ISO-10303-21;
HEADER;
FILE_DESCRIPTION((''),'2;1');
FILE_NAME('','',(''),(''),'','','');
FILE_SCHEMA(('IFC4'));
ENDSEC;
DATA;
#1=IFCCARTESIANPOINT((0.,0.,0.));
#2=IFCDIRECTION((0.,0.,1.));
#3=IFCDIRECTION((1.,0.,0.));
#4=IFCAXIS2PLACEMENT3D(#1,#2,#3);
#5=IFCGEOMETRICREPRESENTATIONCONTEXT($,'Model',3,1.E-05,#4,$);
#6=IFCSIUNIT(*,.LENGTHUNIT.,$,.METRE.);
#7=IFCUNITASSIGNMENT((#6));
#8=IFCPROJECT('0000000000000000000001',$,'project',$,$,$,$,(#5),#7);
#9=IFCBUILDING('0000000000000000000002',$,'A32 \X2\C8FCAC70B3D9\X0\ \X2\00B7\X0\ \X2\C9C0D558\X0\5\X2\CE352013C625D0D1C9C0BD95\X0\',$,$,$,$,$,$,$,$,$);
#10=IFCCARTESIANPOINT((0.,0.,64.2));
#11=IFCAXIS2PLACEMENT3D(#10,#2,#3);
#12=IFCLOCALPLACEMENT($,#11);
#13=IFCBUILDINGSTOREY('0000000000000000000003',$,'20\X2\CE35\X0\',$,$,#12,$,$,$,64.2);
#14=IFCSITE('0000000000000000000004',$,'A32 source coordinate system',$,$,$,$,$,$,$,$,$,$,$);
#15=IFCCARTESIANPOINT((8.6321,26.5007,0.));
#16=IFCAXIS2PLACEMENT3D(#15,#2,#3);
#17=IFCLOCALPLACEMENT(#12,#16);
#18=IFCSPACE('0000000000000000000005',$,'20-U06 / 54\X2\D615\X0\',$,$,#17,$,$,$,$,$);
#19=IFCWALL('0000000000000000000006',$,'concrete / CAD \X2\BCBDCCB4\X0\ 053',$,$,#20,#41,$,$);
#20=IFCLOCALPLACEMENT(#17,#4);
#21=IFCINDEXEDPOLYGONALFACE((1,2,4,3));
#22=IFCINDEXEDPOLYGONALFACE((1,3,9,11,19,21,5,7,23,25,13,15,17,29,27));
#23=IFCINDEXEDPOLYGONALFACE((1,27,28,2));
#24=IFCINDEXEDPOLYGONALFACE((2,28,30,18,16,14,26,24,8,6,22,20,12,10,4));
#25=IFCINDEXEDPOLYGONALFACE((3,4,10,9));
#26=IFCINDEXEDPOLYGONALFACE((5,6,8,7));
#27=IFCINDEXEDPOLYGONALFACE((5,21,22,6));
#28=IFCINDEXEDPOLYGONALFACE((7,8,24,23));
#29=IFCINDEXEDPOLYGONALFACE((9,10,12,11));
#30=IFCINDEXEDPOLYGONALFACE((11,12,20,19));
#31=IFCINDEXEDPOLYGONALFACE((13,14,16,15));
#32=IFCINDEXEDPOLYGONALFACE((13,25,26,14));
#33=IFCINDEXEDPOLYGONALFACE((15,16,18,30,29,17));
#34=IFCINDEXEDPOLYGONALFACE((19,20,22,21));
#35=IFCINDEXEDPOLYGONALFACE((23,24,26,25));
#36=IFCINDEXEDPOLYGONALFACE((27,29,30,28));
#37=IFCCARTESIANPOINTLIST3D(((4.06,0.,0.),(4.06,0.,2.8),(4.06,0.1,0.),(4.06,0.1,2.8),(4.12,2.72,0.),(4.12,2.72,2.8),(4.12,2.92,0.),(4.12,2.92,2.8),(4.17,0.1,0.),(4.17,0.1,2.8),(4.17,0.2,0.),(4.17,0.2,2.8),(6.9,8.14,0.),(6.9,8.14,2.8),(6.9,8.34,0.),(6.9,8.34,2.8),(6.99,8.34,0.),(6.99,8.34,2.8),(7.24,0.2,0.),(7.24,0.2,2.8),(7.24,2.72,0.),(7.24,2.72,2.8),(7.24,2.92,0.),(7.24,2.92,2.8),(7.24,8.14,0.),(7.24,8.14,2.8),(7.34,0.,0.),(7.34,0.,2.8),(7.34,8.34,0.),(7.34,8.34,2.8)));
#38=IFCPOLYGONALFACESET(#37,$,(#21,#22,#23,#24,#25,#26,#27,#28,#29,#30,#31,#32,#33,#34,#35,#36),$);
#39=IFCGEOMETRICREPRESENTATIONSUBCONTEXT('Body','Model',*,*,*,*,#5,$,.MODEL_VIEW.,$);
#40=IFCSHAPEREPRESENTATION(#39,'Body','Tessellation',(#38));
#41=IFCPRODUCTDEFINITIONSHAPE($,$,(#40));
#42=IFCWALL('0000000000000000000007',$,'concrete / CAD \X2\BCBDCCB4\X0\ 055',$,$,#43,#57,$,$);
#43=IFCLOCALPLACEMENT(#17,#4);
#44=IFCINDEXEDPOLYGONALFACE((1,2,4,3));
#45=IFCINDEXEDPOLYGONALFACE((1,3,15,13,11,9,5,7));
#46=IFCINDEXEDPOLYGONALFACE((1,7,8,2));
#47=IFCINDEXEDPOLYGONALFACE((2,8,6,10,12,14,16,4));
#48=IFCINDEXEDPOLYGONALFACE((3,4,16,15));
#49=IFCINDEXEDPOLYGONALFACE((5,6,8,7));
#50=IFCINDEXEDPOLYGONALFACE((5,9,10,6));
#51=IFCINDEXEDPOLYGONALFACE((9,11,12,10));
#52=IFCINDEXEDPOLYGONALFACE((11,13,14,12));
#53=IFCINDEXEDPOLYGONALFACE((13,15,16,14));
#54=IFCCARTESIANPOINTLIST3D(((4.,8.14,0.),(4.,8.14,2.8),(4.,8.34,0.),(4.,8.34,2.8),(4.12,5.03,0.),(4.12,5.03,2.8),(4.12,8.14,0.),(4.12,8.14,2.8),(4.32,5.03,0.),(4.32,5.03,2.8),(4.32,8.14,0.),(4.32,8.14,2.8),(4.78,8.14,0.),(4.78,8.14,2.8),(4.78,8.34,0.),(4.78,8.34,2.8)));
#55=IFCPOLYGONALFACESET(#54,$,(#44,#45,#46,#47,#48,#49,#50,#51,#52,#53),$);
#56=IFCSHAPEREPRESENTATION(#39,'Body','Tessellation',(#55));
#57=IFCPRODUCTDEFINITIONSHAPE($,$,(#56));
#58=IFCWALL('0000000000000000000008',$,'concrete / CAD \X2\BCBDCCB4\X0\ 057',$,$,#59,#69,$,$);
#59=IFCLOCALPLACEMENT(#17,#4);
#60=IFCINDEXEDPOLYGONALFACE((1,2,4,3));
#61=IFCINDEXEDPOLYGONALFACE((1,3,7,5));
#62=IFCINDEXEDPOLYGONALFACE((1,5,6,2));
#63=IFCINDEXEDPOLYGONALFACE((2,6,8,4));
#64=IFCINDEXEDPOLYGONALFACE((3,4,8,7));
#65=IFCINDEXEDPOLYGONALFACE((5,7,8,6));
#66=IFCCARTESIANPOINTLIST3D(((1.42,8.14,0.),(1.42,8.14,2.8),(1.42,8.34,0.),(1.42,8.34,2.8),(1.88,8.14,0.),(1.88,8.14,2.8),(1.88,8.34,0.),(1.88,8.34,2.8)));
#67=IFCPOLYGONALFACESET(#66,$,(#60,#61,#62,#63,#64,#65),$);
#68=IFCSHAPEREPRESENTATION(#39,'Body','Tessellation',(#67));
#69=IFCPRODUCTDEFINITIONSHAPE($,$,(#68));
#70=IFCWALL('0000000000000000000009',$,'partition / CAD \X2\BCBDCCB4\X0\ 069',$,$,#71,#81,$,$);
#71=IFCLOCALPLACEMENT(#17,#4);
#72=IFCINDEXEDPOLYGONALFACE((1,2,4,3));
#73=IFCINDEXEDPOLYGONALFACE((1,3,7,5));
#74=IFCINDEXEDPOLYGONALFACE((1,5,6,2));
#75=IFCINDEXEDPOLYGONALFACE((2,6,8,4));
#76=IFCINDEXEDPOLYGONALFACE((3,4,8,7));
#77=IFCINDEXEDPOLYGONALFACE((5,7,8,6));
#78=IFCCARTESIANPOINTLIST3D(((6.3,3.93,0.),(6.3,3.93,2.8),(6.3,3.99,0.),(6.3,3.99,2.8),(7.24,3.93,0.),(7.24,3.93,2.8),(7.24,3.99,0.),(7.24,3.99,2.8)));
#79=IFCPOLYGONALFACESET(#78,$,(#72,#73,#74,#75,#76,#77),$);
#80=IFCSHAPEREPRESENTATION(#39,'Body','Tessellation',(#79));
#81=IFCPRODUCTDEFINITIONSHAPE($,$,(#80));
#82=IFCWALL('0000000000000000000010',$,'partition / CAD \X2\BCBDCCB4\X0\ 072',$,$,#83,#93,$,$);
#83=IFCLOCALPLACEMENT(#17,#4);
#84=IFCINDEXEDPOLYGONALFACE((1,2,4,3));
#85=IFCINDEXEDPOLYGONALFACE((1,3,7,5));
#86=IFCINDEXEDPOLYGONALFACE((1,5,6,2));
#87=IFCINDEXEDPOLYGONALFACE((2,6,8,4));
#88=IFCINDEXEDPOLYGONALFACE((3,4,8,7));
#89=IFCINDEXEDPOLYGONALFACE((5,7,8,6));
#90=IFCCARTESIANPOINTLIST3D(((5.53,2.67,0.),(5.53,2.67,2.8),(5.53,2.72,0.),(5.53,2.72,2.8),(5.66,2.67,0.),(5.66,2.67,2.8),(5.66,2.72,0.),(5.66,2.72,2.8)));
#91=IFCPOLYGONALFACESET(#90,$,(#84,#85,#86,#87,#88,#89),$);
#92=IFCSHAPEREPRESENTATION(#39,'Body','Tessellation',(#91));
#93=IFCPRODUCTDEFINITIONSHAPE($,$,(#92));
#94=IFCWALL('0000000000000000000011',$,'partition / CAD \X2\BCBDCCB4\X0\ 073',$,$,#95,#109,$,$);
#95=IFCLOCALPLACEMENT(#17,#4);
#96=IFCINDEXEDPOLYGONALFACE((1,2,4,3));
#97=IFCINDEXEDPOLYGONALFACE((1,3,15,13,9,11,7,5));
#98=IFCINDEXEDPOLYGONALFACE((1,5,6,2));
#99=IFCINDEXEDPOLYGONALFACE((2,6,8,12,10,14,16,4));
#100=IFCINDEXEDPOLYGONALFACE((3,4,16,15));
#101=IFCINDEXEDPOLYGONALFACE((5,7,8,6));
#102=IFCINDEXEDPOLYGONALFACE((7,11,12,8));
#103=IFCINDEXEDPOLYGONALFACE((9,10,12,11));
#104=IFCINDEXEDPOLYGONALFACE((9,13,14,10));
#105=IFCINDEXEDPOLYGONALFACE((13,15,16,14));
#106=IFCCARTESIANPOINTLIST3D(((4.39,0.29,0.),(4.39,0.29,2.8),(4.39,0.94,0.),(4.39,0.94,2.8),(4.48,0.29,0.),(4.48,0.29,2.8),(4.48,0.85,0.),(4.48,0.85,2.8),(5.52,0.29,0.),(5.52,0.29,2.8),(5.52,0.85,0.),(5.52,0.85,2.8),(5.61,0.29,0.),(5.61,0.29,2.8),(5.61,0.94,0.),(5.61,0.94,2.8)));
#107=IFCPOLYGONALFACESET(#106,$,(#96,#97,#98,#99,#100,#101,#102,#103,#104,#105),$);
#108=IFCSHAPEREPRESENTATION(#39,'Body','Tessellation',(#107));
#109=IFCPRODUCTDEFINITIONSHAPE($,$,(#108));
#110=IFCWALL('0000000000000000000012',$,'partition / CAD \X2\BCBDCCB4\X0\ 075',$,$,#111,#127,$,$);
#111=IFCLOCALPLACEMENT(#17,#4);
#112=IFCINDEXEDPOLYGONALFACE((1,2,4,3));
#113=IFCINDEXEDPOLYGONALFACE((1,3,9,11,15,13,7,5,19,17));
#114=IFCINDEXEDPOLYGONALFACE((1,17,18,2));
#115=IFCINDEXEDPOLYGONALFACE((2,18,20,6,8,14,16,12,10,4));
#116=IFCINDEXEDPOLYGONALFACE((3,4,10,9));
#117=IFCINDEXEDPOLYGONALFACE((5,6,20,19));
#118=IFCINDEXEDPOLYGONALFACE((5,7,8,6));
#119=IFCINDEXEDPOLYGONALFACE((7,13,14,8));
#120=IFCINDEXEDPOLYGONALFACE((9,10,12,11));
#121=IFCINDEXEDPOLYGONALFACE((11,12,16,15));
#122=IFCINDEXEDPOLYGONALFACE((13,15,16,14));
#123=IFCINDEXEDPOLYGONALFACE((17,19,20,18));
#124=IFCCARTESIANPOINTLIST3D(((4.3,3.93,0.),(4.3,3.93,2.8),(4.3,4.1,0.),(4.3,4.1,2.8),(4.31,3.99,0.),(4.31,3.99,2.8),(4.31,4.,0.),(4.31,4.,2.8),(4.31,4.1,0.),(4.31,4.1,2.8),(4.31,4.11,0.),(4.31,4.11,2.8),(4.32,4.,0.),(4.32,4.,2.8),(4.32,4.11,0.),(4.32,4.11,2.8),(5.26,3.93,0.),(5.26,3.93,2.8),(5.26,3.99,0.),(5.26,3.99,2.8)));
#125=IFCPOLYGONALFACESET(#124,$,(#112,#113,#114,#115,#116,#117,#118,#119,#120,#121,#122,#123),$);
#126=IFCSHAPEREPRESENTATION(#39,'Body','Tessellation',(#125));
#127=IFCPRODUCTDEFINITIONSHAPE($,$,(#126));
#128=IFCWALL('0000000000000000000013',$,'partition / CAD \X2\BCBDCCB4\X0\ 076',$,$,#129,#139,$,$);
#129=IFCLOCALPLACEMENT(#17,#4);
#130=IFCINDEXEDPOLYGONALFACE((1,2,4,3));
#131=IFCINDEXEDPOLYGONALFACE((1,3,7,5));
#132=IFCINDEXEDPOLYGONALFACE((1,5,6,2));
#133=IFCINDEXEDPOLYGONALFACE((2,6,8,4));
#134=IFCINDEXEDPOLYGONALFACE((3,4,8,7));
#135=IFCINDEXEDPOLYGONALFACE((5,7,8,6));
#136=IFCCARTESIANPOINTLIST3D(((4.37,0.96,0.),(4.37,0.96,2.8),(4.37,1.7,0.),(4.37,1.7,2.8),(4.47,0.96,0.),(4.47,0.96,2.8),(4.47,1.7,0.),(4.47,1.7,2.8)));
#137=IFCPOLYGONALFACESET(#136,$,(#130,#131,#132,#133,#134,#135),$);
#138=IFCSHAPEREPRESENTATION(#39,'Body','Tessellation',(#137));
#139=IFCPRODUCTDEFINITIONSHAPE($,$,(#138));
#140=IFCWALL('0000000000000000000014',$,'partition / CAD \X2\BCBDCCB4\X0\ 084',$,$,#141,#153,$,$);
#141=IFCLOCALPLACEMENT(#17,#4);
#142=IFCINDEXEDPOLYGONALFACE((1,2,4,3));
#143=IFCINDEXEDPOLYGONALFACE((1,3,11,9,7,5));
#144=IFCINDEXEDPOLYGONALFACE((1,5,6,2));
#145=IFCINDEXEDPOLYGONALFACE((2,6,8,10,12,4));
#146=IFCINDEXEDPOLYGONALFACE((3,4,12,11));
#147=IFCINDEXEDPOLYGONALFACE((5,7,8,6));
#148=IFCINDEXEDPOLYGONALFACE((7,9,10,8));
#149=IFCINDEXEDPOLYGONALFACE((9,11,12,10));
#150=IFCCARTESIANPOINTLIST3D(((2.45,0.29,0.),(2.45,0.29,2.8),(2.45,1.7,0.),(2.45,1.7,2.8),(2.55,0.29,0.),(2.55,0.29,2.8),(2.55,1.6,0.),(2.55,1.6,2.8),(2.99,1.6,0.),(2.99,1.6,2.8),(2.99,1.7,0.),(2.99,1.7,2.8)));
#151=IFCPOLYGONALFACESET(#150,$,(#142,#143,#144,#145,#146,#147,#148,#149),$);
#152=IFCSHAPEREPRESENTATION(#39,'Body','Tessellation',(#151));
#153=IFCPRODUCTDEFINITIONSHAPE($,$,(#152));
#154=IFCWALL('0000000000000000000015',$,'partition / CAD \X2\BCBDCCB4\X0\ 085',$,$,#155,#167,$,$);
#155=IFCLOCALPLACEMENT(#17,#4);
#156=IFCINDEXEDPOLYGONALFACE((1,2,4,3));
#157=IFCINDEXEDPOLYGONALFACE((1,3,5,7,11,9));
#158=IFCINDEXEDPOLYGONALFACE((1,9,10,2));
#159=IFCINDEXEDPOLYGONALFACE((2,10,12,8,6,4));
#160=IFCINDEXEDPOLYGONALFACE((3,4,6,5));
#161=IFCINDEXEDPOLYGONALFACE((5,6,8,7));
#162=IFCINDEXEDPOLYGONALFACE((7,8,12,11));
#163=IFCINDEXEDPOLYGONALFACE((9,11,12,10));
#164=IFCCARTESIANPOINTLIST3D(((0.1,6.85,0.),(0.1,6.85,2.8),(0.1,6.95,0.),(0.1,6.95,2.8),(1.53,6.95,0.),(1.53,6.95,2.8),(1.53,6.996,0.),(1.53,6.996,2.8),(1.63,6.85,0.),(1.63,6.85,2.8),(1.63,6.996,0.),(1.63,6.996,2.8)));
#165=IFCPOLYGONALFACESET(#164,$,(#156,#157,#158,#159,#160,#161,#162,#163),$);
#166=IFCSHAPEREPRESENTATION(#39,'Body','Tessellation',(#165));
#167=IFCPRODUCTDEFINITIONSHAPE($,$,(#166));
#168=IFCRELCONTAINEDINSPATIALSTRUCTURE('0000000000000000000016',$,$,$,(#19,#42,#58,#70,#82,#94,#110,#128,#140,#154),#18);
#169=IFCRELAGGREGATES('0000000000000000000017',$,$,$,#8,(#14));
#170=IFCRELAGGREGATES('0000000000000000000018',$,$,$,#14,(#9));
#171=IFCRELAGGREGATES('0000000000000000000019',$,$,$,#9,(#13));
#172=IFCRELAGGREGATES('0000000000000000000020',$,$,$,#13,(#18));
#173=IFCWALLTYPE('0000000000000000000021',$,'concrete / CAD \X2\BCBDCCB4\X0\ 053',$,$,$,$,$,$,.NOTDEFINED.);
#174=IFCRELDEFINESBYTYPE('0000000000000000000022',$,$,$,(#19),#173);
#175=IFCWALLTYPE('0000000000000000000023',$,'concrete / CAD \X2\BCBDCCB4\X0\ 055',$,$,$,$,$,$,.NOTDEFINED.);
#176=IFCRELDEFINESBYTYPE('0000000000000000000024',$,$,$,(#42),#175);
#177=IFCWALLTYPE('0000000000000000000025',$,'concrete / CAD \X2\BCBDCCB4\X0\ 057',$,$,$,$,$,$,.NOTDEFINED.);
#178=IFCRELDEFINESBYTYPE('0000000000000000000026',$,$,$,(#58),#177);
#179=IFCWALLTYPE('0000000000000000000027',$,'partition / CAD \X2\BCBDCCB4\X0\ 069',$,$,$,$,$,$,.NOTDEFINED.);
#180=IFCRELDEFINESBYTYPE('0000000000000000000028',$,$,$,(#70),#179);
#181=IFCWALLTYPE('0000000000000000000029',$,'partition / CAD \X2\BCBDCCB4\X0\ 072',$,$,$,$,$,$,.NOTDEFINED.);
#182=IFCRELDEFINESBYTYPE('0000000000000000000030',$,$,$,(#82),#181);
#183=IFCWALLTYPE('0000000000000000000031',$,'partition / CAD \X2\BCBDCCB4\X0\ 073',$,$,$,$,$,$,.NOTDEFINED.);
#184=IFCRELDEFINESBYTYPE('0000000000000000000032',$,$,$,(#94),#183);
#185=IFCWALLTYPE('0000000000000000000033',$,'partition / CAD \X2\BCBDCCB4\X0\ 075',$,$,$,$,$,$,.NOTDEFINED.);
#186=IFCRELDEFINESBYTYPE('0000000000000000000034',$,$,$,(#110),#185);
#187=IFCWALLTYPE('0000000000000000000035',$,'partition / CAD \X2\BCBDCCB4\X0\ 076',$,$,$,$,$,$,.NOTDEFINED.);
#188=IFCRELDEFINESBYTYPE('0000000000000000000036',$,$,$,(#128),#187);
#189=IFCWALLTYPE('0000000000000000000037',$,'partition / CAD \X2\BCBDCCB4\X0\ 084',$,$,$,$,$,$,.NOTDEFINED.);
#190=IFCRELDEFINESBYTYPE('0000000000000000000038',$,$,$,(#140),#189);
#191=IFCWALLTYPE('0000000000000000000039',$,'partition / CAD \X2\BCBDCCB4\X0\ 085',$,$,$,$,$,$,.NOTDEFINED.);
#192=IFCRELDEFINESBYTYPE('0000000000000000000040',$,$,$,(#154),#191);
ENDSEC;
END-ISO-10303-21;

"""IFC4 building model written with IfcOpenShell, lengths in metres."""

from ifc_helpers import new_model, si_unit, frame, origin, origin_with_axes, place, context, subcontext, project, spatial, polyline, outline, extrude, source, transform, mapped, type_object, type_shapes, element, save


model = new_model("IFC4")

# Units and contexts
model_context = context("Model", 3, precision=1e-05, world=origin_with_axes())
body_context = subcontext(model_context, "Body", "Model", "MODEL_VIEW")
ifc_project = project(units=[si_unit("LENGTHUNIT", "METRE")], contexts=[model_context])

# Site, building, storey, space
site = spatial("IfcSite", under=ifc_project, Name="A32 source coordinate system")
building = spatial("IfcBuilding", under=site, Name="A32 주거동 · 지하5층–옥탑지붕")
storey_placement = place(None, frame((0.0, 0.0, 64.2), z_axis=(0.0, 0.0, 1.0), x_axis=(1.0, 0.0, 0.0)))
storey = spatial("IfcBuildingStorey", under=building, at=storey_placement, Name="20층", Elevation=64.2)
space_placement = place(storey_placement, frame((8.6321, 26.5007, 0.0), z_axis=(0.0, 0.0, 1.0), x_axis=(1.0, 0.0, 0.0)))
space = spatial("IfcSpace", under=storey, at=space_placement, Name="20-U06 / 54형")

# Walls
wall_type_1 = type_object("IfcWallType", Name="concrete / CAD 벽체 053", PredefinedType="NOTDEFINED")
shared_shape_1 = source(origin(), body_context, "Body", "SweptSolid", [
    extrude(outline(polyline([(7.24, 8.14), (6.9, 8.14), (6.9, 8.34), (6.99, 8.34), (6.99, 8.34), (7.34, 8.34), (7.34, 8.34), (7.34, 0.0), (4.06, 0.0), (4.06, 0.1), (4.17, 0.1), (4.17, 0.2), (7.24, 0.2), (7.24, 2.72), (4.12, 2.72), (4.12, 2.92), (7.24, 2.92), (7.24, 8.14)])), origin(), (0.0, 0.0, 1.0), 2.8),
])
type_shapes(wall_type_1, [shared_shape_1])
wall_1_placement = place(space_placement, origin_with_axes())
element("IfcWall", 1, at=wall_1_placement, inside=space, type_object=wall_type_1, Name="concrete / CAD 벽체 053", context=body_context, shape_type="MappedRepresentation", body=[
    mapped(shared_shape_1, transform((0.0, 0.0, 0.0), scale=1.0)),
])
wall_type_2 = type_object("IfcWallType", Name="concrete / CAD 벽체 055", PredefinedType="NOTDEFINED")
shared_shape_2 = source(origin(), body_context, "Body", "SweptSolid", [
    extrude(outline(polyline([(4.32, 5.03), (4.12, 5.03), (4.12, 8.14), (4.0, 8.14), (4.0, 8.34), (4.78, 8.34), (4.78, 8.14), (4.32, 8.14), (4.32, 5.03)])), origin(), (0.0, 0.0, 1.0), 2.8),
])
type_shapes(wall_type_2, [shared_shape_2])
wall_2_placement = place(space_placement, origin_with_axes())
element("IfcWall", 2, at=wall_2_placement, inside=space, type_object=wall_type_2, Name="concrete / CAD 벽체 055", context=body_context, shape_type="MappedRepresentation", body=[
    mapped(shared_shape_2, transform((0.0, 0.0, 0.0), scale=1.0)),
])
wall_type_3 = type_object("IfcWallType", Name="concrete / CAD 벽체 057", PredefinedType="NOTDEFINED")
shared_shape_3 = source(origin(), body_context, "Body", "SweptSolid", [
    extrude(outline(polyline([(1.42, 8.14), (1.42, 8.34), (1.88, 8.34), (1.88, 8.14), (1.42, 8.14)])), origin(), (0.0, 0.0, 1.0), 2.8),
])
type_shapes(wall_type_3, [shared_shape_3])
wall_3_placement = place(space_placement, origin_with_axes())
element("IfcWall", 3, at=wall_3_placement, inside=space, type_object=wall_type_3, Name="concrete / CAD 벽체 057", context=body_context, shape_type="MappedRepresentation", body=[
    mapped(shared_shape_3, transform((0.0, 0.0, 0.0), scale=1.0)),
])
wall_type_4 = type_object("IfcWallType", Name="partition / CAD 벽체 069", PredefinedType="NOTDEFINED")
shared_shape_4 = source(origin(), body_context, "Body", "SweptSolid", [
    extrude(outline(polyline([(7.24, 3.93), (6.3, 3.93), (6.3, 3.99), (7.24, 3.99), (7.24, 3.93)])), origin(), (0.0, 0.0, 1.0), 2.8),
])
type_shapes(wall_type_4, [shared_shape_4])
wall_4_placement = place(space_placement, origin_with_axes())
element("IfcWall", 4, at=wall_4_placement, inside=space, type_object=wall_type_4, Name="partition / CAD 벽체 069", context=body_context, shape_type="MappedRepresentation", body=[
    mapped(shared_shape_4, transform((0.0, 0.0, 0.0), scale=1.0)),
])
wall_type_5 = type_object("IfcWallType", Name="partition / CAD 벽체 072", PredefinedType="NOTDEFINED")
shared_shape_5 = source(origin(), body_context, "Body", "SweptSolid", [
    extrude(outline(polyline([(5.66, 2.67), (5.53, 2.67), (5.53, 2.72), (5.66, 2.72), (5.66, 2.67)])), origin(), (0.0, 0.0, 1.0), 2.8),
])
type_shapes(wall_type_5, [shared_shape_5])
wall_5_placement = place(space_placement, origin_with_axes())
element("IfcWall", 5, at=wall_5_placement, inside=space, type_object=wall_type_5, Name="partition / CAD 벽체 072", context=body_context, shape_type="MappedRepresentation", body=[
    mapped(shared_shape_5, transform((0.0, 0.0, 0.0), scale=1.0)),
])
wall_type_6 = type_object("IfcWallType", Name="partition / CAD 벽체 073", PredefinedType="NOTDEFINED")
shared_shape_6 = source(origin(), body_context, "Body", "SweptSolid", [
    extrude(outline(polyline([(4.48, 0.29), (4.39, 0.29), (4.39, 0.94), (5.61, 0.94), (5.61, 0.29), (5.52, 0.29), (5.52, 0.85), (4.48, 0.85), (4.48, 0.29)])), origin(), (0.0, 0.0, 1.0), 2.8),
])
type_shapes(wall_type_6, [shared_shape_6])
wall_6_placement = place(space_placement, origin_with_axes())
element("IfcWall", 6, at=wall_6_placement, inside=space, type_object=wall_type_6, Name="partition / CAD 벽체 073", context=body_context, shape_type="MappedRepresentation", body=[
    mapped(shared_shape_6, transform((0.0, 0.0, 0.0), scale=1.0)),
])
wall_type_7 = type_object("IfcWallType", Name="partition / CAD 벽체 075", PredefinedType="NOTDEFINED")
shared_shape_7 = source(origin(), body_context, "Body", "SweptSolid", [
    extrude(outline(polyline([(4.32, 4.0), (4.31, 4.0), (4.31, 3.99), (5.26, 3.99), (5.26, 3.93), (4.3, 3.93), (4.3, 4.1), (4.31, 4.1), (4.31, 4.11), (4.32, 4.11), (4.32, 4.0)])), origin(), (0.0, 0.0, 1.0), 2.8),
])
type_shapes(wall_type_7, [shared_shape_7])
wall_7_placement = place(space_placement, origin_with_axes())
element("IfcWall", 7, at=wall_7_placement, inside=space, type_object=wall_type_7, Name="partition / CAD 벽체 075", context=body_context, shape_type="MappedRepresentation", body=[
    mapped(shared_shape_7, transform((0.0, 0.0, 0.0), scale=1.0)),
])
wall_type_8 = type_object("IfcWallType", Name="partition / CAD 벽체 076", PredefinedType="NOTDEFINED")
shared_shape_8 = source(origin(), body_context, "Body", "SweptSolid", [
    extrude(outline(polyline([(4.37, 1.7), (4.47, 1.7), (4.47, 0.96), (4.37, 0.96), (4.37, 1.7)])), origin(), (0.0, 0.0, 1.0), 2.8),
])
type_shapes(wall_type_8, [shared_shape_8])
wall_8_placement = place(space_placement, origin_with_axes())
element("IfcWall", 8, at=wall_8_placement, inside=space, type_object=wall_type_8, Name="partition / CAD 벽체 076", context=body_context, shape_type="MappedRepresentation", body=[
    mapped(shared_shape_8, transform((0.0, 0.0, 0.0), scale=1.0)),
])
wall_type_9 = type_object("IfcWallType", Name="partition / CAD 벽체 084", PredefinedType="NOTDEFINED")
shared_shape_9 = source(origin(), body_context, "Body", "SweptSolid", [
    extrude(outline(polyline([(2.99, 1.6), (2.55, 1.6), (2.55, 0.29), (2.45, 0.29), (2.45, 1.7), (2.99, 1.7), (2.99, 1.6)])), origin(), (0.0, 0.0, 1.0), 2.8),
])
type_shapes(wall_type_9, [shared_shape_9])
wall_9_placement = place(space_placement, origin_with_axes())
element("IfcWall", 9, at=wall_9_placement, inside=space, type_object=wall_type_9, Name="partition / CAD 벽체 084", context=body_context, shape_type="MappedRepresentation", body=[
    mapped(shared_shape_9, transform((0.0, 0.0, 0.0), scale=1.0)),
])
wall_type_10 = type_object("IfcWallType", Name="partition / CAD 벽체 085", PredefinedType="NOTDEFINED")
shared_shape_10 = source(origin(), body_context, "Body", "SweptSolid", [
    extrude(outline(polyline([(1.63, 6.85), (0.1, 6.85), (0.1, 6.95), (1.53, 6.95), (1.53, 6.996), (1.63, 6.996), (1.63, 6.85)])), origin(), (0.0, 0.0, 1.0), 2.8),
])
type_shapes(wall_type_10, [shared_shape_10])
wall_10_placement = place(space_placement, origin_with_axes())
element("IfcWall", 10, at=wall_10_placement, inside=space, type_object=wall_type_10, Name="partition / CAD 벽체 085", context=body_context, shape_type="MappedRepresentation", body=[
    mapped(shared_shape_10, transform((0.0, 0.0, 0.0), scale=1.0)),
])

save(model, "model.ifc")
